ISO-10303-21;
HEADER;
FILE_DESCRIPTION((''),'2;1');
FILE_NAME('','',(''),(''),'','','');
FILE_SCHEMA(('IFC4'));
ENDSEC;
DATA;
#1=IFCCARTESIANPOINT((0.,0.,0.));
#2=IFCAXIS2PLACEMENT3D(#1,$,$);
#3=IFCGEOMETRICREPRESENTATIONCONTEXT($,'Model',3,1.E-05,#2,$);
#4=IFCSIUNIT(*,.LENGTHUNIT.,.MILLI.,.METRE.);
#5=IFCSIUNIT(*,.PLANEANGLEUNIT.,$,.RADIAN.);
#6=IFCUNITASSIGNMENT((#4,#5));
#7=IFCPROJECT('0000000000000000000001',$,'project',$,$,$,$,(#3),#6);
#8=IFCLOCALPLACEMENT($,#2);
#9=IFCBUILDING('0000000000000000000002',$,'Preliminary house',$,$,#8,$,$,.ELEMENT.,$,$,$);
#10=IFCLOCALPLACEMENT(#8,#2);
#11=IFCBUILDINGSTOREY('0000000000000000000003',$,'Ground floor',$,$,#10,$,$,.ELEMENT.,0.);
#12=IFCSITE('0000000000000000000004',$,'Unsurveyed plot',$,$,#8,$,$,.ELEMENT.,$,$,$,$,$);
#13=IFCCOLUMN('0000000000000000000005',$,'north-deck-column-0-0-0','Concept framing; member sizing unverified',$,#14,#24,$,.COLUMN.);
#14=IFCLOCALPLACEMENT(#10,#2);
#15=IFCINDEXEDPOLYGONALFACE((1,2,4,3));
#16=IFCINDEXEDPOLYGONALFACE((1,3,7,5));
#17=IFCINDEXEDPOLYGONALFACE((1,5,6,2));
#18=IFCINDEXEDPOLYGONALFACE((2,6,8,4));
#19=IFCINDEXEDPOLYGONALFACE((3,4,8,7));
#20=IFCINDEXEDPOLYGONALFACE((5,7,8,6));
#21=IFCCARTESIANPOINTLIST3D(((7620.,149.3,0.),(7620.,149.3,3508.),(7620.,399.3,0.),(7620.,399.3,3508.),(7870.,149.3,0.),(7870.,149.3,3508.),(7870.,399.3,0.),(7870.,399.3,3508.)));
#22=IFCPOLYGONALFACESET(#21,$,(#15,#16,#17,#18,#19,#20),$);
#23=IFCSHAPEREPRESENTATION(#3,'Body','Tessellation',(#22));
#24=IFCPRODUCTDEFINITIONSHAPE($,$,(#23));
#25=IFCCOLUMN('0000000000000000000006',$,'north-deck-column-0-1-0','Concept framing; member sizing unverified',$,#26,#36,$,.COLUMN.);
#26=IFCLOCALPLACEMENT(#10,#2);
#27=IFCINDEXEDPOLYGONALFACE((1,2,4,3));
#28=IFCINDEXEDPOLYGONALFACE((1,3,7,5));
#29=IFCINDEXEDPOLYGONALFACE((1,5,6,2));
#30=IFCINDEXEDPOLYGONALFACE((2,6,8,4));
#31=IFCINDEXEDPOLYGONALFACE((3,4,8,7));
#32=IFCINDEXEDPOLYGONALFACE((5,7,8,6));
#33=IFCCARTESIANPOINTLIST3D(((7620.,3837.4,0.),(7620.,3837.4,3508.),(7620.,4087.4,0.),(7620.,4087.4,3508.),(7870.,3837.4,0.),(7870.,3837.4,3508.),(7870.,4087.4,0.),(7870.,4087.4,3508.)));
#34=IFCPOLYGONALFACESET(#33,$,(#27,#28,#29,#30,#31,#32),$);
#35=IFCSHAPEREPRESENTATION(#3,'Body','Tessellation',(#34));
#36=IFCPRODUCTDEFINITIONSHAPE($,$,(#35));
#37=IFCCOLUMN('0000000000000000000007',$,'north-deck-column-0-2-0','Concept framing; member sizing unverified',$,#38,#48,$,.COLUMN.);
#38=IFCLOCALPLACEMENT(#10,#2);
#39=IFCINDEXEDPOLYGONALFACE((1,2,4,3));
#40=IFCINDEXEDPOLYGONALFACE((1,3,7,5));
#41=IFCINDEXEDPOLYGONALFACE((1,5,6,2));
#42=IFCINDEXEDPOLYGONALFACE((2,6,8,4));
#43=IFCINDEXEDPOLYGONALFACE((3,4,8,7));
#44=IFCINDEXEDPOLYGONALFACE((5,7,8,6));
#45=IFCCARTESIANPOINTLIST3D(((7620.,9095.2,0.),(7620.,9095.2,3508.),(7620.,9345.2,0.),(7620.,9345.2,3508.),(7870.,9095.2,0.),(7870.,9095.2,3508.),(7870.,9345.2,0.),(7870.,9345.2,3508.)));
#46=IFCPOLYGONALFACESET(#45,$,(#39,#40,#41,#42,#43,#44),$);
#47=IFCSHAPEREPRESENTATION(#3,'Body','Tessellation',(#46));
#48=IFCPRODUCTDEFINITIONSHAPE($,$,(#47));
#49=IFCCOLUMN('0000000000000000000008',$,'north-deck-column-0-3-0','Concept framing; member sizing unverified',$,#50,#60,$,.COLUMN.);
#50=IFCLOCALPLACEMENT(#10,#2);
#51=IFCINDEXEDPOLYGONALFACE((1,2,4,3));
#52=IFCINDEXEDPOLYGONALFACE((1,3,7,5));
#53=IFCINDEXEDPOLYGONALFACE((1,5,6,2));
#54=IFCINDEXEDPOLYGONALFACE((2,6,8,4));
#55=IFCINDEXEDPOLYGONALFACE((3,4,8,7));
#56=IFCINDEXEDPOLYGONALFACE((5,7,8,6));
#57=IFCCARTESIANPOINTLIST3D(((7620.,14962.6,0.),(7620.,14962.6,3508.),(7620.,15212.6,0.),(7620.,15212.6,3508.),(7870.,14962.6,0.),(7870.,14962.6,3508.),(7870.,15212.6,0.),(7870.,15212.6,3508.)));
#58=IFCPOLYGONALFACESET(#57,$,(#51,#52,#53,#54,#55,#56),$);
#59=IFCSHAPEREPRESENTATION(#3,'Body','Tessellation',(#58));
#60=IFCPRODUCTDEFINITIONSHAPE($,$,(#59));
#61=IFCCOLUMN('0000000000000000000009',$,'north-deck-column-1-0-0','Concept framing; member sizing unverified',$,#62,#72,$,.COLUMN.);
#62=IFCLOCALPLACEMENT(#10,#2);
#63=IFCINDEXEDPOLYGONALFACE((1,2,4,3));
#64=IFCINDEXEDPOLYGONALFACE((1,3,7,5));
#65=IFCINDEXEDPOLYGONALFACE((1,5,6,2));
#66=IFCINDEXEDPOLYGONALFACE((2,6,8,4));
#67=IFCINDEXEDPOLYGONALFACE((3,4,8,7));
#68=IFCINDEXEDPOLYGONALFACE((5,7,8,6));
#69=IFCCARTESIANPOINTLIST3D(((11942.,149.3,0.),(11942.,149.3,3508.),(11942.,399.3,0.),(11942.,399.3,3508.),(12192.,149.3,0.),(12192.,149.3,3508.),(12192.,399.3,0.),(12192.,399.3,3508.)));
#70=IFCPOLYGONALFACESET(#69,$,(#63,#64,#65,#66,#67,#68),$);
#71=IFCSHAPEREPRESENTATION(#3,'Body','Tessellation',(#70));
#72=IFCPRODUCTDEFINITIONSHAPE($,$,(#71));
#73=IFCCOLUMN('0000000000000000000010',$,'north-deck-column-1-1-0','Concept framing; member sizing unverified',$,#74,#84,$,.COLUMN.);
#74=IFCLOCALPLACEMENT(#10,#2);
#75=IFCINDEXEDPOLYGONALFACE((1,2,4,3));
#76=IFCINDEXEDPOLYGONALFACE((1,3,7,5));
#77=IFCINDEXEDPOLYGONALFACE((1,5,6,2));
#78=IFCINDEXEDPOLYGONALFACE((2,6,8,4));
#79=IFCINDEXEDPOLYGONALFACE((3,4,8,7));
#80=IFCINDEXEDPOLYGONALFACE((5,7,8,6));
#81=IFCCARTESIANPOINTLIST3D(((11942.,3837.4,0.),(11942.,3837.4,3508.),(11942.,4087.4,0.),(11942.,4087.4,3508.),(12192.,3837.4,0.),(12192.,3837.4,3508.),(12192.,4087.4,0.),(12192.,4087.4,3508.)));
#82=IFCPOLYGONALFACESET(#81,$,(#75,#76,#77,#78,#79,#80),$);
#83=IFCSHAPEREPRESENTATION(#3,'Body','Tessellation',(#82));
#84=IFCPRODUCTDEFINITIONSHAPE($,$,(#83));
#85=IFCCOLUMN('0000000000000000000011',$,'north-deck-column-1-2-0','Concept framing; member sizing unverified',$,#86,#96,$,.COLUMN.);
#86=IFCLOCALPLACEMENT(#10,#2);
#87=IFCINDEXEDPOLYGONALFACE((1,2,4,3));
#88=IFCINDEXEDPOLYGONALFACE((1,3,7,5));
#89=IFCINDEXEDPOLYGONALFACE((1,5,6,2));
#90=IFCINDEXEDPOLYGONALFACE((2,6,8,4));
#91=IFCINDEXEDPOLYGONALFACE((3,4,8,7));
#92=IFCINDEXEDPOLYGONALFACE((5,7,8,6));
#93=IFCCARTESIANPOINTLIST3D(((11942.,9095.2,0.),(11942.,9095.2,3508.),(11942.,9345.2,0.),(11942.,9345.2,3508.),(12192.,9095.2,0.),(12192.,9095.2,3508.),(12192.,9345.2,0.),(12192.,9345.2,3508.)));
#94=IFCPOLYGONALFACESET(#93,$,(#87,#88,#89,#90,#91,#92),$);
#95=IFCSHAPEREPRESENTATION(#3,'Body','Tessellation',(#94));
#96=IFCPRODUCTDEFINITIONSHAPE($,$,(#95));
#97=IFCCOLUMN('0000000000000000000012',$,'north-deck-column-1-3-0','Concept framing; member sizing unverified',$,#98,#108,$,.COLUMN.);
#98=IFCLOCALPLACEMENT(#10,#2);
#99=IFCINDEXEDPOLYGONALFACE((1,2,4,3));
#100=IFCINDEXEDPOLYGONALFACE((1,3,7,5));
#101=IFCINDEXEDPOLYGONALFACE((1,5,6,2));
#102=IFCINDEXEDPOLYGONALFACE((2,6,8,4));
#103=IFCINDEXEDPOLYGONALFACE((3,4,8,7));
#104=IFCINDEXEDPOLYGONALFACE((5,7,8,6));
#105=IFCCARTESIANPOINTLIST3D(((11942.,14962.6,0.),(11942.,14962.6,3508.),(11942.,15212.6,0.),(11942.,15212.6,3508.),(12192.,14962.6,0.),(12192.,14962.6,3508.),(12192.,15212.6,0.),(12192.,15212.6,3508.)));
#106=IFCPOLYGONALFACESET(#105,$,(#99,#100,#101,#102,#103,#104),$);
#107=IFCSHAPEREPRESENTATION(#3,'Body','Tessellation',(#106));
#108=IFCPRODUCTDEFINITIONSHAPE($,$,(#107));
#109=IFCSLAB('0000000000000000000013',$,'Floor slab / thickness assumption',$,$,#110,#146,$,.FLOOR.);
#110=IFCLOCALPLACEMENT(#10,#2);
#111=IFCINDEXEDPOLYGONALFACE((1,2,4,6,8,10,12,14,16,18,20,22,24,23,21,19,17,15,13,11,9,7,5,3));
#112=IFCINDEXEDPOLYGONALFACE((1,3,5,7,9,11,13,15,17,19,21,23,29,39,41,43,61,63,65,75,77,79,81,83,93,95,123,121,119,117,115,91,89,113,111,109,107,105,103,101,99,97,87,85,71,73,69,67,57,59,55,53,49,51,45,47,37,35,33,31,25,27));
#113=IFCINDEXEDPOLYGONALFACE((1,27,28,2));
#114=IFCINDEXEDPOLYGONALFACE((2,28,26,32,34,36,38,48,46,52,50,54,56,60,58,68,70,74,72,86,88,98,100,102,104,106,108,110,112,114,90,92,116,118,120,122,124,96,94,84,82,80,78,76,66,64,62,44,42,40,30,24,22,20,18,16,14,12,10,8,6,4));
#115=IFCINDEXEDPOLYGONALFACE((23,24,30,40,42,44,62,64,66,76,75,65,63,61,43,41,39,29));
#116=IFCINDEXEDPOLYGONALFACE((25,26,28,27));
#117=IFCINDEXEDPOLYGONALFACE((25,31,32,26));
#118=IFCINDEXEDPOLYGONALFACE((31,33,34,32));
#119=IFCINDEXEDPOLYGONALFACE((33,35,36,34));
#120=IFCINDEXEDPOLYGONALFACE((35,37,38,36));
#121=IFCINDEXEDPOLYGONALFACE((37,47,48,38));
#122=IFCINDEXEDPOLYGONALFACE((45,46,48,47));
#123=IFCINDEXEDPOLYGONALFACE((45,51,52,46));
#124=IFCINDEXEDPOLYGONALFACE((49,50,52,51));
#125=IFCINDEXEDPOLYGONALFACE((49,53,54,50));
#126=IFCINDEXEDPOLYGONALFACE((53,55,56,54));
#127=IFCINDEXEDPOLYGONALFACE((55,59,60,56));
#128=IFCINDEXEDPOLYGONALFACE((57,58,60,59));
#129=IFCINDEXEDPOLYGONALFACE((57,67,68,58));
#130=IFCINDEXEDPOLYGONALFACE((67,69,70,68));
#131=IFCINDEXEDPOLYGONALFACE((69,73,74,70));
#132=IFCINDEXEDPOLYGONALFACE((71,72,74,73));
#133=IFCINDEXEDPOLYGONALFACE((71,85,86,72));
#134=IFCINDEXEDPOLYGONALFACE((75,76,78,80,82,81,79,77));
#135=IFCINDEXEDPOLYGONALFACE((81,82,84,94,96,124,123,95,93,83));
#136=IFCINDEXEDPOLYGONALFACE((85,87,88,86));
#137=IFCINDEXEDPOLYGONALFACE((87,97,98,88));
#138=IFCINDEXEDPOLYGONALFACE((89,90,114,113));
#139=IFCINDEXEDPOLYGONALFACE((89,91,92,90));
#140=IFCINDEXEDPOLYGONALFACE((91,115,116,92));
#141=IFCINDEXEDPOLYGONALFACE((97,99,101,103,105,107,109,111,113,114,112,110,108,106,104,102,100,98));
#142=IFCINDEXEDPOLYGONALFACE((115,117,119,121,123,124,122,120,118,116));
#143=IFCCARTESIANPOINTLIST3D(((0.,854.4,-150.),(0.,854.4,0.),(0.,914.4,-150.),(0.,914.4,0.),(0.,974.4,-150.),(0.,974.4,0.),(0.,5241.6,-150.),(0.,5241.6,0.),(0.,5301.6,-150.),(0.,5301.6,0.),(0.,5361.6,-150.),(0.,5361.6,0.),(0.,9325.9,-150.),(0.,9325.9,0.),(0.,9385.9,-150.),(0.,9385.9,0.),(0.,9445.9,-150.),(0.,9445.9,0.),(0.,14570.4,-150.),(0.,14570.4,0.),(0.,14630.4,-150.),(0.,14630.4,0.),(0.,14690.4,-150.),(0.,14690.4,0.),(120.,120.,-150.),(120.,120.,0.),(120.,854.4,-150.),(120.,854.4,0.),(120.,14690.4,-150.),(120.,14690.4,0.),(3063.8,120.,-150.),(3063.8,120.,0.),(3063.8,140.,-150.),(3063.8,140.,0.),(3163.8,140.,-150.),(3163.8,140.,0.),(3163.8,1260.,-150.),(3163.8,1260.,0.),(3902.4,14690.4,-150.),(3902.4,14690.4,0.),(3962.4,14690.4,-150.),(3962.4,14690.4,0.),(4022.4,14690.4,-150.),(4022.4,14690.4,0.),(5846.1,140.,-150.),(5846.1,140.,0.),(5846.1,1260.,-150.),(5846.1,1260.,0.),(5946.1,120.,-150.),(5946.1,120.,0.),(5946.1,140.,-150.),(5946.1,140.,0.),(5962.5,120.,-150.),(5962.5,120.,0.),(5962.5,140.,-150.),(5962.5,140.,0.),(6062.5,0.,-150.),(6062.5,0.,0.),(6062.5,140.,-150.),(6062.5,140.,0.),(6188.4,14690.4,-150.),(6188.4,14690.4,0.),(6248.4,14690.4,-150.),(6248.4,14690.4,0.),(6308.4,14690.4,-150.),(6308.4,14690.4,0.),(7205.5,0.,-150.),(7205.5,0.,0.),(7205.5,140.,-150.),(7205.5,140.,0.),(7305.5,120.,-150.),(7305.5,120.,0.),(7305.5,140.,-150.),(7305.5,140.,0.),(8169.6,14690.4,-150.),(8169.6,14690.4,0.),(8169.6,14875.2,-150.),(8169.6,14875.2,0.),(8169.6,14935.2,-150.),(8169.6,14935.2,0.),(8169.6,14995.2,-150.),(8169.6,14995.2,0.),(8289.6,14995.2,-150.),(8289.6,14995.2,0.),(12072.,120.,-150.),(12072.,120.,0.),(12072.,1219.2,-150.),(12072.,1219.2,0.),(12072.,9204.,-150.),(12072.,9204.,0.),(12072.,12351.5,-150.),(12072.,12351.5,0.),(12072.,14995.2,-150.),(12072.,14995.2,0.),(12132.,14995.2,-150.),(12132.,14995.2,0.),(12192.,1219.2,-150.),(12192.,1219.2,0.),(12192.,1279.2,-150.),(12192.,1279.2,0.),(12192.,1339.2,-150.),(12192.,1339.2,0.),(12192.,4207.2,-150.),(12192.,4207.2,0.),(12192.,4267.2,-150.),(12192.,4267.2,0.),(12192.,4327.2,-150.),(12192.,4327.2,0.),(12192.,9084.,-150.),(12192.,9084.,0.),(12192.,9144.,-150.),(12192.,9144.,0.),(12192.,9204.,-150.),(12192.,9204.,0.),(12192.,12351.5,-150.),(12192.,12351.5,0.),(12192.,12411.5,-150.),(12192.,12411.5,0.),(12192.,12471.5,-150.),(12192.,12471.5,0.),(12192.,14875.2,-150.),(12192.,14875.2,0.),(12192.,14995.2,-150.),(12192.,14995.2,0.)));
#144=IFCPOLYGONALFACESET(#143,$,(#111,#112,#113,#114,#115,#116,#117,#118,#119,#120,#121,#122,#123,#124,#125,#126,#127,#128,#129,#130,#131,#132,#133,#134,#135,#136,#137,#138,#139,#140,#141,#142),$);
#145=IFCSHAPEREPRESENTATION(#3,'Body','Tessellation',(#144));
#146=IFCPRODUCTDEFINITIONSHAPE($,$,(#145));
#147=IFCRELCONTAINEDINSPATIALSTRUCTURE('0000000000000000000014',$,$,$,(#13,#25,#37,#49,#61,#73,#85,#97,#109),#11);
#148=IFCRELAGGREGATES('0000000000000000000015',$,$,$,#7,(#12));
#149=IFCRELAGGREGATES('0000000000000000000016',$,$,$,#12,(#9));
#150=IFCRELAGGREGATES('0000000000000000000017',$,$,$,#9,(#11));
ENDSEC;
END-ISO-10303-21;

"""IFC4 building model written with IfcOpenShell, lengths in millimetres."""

from ifc_helpers import new_model, si_unit, frame, origin, place, context, project, spatial, polyline, outline, extrude, element, save


model = new_model("IFC4")

# Units and contexts
model_context = context("Model", 3, precision=1e-05, world=origin())
ifc_project = project(units=[si_unit("LENGTHUNIT", "METRE", prefix="MILLI"), si_unit("PLANEANGLEUNIT", "RADIAN")], contexts=[model_context])

# Site, building, storey
placement_1 = place(None, origin())
site = spatial("IfcSite", under=ifc_project, at=placement_1, Name="Unsurveyed plot", CompositionType="ELEMENT")
building = spatial("IfcBuilding", under=site, at=placement_1, Name="Preliminary house", CompositionType="ELEMENT")
placement_2 = place(placement_1, origin())
storey = spatial("IfcBuildingStorey", under=building, at=placement_2, Name="Ground floor", CompositionType="ELEMENT", Elevation=0.0)

# Columns
element("IfcColumn", 1, at=placement_2, inside=storey, Name="north-deck-column-0-0-0", Description="Concept framing; member sizing unverified", PredefinedType="COLUMN", context=model_context, shape_type="SweptSolid", body=[
    extrude(outline(polyline([(7870.0, 149.3), (7870.0, 399.3), (7620.0, 399.3), (7620.0, 149.3), (7870.0, 149.3)])), origin(), (0.0, 0.0, 1.0), 3508.0),
])
element("IfcColumn", 2, at=placement_2, inside=storey, Name="north-deck-column-0-1-0", Description="Concept framing; member sizing unverified", PredefinedType="COLUMN", context=model_context, shape_type="SweptSolid", body=[
    extrude(outline(polyline([(7870.0, 3837.4), (7870.0, 4087.4), (7620.0, 4087.4), (7620.0, 3837.4), (7870.0, 3837.4)])), origin(), (0.0, 0.0, 1.0), 3508.0),
])
element("IfcColumn", 3, at=placement_2, inside=storey, Name="north-deck-column-0-2-0", Description="Concept framing; member sizing unverified", PredefinedType="COLUMN", context=model_context, shape_type="SweptSolid", body=[
    extrude(outline(polyline([(7870.0, 9095.2), (7870.0, 9345.2), (7620.0, 9345.2), (7620.0, 9095.2), (7870.0, 9095.2)])), origin(), (0.0, 0.0, 1.0), 3508.0),
])
element("IfcColumn", 4, at=placement_2, inside=storey, Name="north-deck-column-0-3-0", Description="Concept framing; member sizing unverified", PredefinedType="COLUMN", context=model_context, shape_type="SweptSolid", body=[
    extrude(outline(polyline([(7870.0, 14962.6), (7870.0, 15212.6), (7620.0, 15212.6), (7620.0, 14962.6), (7870.0, 14962.6)])), origin(), (0.0, 0.0, 1.0), 3508.0),
])
element("IfcColumn", 5, at=placement_2, inside=storey, Name="north-deck-column-1-0-0", Description="Concept framing; member sizing unverified", PredefinedType="COLUMN", context=model_context, shape_type="SweptSolid", body=[
    extrude(outline(polyline([(12192.0, 149.3), (12192.0, 399.3), (11942.0, 399.3), (11942.0, 149.3), (12192.0, 149.3)])), origin(), (0.0, 0.0, 1.0), 3508.0),
])
element("IfcColumn", 6, at=placement_2, inside=storey, Name="north-deck-column-1-1-0", Description="Concept framing; member sizing unverified", PredefinedType="COLUMN", context=model_context, shape_type="SweptSolid", body=[
    extrude(outline(polyline([(12192.0, 3837.4), (12192.0, 4087.4), (11942.0, 4087.4), (11942.0, 3837.4), (12192.0, 3837.4)])), origin(), (0.0, 0.0, 1.0), 3508.0),
])
element("IfcColumn", 7, at=placement_2, inside=storey, Name="north-deck-column-1-2-0", Description="Concept framing; member sizing unverified", PredefinedType="COLUMN", context=model_context, shape_type="SweptSolid", body=[
    extrude(outline(polyline([(12192.0, 9095.2), (12192.0, 9345.2), (11942.0, 9345.2), (11942.0, 9095.2), (12192.0, 9095.2)])), origin(), (0.0, 0.0, 1.0), 3508.0),
])
element("IfcColumn", 8, at=placement_2, inside=storey, Name="north-deck-column-1-3-0", Description="Concept framing; member sizing unverified", PredefinedType="COLUMN", context=model_context, shape_type="SweptSolid", body=[
    extrude(outline(polyline([(12192.0, 14962.6), (12192.0, 15212.6), (11942.0, 15212.6), (11942.0, 14962.6), (12192.0, 14962.6)])), origin(), (0.0, 0.0, 1.0), 3508.0),
])

# Slab
element("IfcSlab", 9, at=placement_2, inside=storey, Name="Floor slab / thickness assumption", PredefinedType="FLOOR", context=model_context, shape_type="SweptSolid", body=[
    extrude(outline(polyline([(0.0, 9385.9), (0.0, 9445.9), (0.0, 14570.4), (0.0, 14630.4), (0.0, 14690.4), (120.0, 14690.4), (3902.4, 14690.4), (3962.4, 14690.4), (4022.4, 14690.4), (6188.4, 14690.4), (6248.4, 14690.4), (6308.4, 14690.4), (8169.6, 14690.4), (8169.6, 14875.2), (8169.6, 14935.2), (8169.6, 14995.2), (8289.6, 14995.2), (12072.0, 14995.2), (12132.0, 14995.2), (12192.0, 14995.2), (12192.0, 14875.2), (12192.0, 12471.5), (12192.0, 12411.5), (12192.0, 12351.5), (12072.0, 12351.5), (12072.0, 9204.0), (12192.0, 9204.0), (12192.0, 9144.0), (12192.0, 9084.0), (12192.0, 4327.2), (12192.0, 4267.2), (12192.0, 4207.2), (12192.0, 1339.2), (12192.0, 1279.2), (12192.0, 1219.2), (12072.0, 1219.2), (12072.0, 120.0), (7305.5, 120.0), (7305.5, 140.0), (7205.5, 140.0), (7205.5, 0.0), (6062.5, 0.0), (6062.5, 140.0), (5962.5, 140.0), (5962.5, 120.0), (5946.1, 120.0), (5946.1, 140.0), (5846.1, 140.0), (5846.1, 1260.0), (3163.8, 1260.0), (3163.8, 140.0), (3063.8, 140.0), (3063.8, 120.0), (120.0, 120.0), (120.0, 854.4), (0.0, 854.4), (0.0, 914.4), (0.0, 974.4), (0.0, 5241.6), (0.0, 5301.6), (0.0, 5361.6), (0.0, 9325.9), (0.0, 9385.9)])), frame((0.0, 0.0, -150.0)), (0.0, 0.0, 1.0), 150.0),
])

save(model, "model.ifc")
